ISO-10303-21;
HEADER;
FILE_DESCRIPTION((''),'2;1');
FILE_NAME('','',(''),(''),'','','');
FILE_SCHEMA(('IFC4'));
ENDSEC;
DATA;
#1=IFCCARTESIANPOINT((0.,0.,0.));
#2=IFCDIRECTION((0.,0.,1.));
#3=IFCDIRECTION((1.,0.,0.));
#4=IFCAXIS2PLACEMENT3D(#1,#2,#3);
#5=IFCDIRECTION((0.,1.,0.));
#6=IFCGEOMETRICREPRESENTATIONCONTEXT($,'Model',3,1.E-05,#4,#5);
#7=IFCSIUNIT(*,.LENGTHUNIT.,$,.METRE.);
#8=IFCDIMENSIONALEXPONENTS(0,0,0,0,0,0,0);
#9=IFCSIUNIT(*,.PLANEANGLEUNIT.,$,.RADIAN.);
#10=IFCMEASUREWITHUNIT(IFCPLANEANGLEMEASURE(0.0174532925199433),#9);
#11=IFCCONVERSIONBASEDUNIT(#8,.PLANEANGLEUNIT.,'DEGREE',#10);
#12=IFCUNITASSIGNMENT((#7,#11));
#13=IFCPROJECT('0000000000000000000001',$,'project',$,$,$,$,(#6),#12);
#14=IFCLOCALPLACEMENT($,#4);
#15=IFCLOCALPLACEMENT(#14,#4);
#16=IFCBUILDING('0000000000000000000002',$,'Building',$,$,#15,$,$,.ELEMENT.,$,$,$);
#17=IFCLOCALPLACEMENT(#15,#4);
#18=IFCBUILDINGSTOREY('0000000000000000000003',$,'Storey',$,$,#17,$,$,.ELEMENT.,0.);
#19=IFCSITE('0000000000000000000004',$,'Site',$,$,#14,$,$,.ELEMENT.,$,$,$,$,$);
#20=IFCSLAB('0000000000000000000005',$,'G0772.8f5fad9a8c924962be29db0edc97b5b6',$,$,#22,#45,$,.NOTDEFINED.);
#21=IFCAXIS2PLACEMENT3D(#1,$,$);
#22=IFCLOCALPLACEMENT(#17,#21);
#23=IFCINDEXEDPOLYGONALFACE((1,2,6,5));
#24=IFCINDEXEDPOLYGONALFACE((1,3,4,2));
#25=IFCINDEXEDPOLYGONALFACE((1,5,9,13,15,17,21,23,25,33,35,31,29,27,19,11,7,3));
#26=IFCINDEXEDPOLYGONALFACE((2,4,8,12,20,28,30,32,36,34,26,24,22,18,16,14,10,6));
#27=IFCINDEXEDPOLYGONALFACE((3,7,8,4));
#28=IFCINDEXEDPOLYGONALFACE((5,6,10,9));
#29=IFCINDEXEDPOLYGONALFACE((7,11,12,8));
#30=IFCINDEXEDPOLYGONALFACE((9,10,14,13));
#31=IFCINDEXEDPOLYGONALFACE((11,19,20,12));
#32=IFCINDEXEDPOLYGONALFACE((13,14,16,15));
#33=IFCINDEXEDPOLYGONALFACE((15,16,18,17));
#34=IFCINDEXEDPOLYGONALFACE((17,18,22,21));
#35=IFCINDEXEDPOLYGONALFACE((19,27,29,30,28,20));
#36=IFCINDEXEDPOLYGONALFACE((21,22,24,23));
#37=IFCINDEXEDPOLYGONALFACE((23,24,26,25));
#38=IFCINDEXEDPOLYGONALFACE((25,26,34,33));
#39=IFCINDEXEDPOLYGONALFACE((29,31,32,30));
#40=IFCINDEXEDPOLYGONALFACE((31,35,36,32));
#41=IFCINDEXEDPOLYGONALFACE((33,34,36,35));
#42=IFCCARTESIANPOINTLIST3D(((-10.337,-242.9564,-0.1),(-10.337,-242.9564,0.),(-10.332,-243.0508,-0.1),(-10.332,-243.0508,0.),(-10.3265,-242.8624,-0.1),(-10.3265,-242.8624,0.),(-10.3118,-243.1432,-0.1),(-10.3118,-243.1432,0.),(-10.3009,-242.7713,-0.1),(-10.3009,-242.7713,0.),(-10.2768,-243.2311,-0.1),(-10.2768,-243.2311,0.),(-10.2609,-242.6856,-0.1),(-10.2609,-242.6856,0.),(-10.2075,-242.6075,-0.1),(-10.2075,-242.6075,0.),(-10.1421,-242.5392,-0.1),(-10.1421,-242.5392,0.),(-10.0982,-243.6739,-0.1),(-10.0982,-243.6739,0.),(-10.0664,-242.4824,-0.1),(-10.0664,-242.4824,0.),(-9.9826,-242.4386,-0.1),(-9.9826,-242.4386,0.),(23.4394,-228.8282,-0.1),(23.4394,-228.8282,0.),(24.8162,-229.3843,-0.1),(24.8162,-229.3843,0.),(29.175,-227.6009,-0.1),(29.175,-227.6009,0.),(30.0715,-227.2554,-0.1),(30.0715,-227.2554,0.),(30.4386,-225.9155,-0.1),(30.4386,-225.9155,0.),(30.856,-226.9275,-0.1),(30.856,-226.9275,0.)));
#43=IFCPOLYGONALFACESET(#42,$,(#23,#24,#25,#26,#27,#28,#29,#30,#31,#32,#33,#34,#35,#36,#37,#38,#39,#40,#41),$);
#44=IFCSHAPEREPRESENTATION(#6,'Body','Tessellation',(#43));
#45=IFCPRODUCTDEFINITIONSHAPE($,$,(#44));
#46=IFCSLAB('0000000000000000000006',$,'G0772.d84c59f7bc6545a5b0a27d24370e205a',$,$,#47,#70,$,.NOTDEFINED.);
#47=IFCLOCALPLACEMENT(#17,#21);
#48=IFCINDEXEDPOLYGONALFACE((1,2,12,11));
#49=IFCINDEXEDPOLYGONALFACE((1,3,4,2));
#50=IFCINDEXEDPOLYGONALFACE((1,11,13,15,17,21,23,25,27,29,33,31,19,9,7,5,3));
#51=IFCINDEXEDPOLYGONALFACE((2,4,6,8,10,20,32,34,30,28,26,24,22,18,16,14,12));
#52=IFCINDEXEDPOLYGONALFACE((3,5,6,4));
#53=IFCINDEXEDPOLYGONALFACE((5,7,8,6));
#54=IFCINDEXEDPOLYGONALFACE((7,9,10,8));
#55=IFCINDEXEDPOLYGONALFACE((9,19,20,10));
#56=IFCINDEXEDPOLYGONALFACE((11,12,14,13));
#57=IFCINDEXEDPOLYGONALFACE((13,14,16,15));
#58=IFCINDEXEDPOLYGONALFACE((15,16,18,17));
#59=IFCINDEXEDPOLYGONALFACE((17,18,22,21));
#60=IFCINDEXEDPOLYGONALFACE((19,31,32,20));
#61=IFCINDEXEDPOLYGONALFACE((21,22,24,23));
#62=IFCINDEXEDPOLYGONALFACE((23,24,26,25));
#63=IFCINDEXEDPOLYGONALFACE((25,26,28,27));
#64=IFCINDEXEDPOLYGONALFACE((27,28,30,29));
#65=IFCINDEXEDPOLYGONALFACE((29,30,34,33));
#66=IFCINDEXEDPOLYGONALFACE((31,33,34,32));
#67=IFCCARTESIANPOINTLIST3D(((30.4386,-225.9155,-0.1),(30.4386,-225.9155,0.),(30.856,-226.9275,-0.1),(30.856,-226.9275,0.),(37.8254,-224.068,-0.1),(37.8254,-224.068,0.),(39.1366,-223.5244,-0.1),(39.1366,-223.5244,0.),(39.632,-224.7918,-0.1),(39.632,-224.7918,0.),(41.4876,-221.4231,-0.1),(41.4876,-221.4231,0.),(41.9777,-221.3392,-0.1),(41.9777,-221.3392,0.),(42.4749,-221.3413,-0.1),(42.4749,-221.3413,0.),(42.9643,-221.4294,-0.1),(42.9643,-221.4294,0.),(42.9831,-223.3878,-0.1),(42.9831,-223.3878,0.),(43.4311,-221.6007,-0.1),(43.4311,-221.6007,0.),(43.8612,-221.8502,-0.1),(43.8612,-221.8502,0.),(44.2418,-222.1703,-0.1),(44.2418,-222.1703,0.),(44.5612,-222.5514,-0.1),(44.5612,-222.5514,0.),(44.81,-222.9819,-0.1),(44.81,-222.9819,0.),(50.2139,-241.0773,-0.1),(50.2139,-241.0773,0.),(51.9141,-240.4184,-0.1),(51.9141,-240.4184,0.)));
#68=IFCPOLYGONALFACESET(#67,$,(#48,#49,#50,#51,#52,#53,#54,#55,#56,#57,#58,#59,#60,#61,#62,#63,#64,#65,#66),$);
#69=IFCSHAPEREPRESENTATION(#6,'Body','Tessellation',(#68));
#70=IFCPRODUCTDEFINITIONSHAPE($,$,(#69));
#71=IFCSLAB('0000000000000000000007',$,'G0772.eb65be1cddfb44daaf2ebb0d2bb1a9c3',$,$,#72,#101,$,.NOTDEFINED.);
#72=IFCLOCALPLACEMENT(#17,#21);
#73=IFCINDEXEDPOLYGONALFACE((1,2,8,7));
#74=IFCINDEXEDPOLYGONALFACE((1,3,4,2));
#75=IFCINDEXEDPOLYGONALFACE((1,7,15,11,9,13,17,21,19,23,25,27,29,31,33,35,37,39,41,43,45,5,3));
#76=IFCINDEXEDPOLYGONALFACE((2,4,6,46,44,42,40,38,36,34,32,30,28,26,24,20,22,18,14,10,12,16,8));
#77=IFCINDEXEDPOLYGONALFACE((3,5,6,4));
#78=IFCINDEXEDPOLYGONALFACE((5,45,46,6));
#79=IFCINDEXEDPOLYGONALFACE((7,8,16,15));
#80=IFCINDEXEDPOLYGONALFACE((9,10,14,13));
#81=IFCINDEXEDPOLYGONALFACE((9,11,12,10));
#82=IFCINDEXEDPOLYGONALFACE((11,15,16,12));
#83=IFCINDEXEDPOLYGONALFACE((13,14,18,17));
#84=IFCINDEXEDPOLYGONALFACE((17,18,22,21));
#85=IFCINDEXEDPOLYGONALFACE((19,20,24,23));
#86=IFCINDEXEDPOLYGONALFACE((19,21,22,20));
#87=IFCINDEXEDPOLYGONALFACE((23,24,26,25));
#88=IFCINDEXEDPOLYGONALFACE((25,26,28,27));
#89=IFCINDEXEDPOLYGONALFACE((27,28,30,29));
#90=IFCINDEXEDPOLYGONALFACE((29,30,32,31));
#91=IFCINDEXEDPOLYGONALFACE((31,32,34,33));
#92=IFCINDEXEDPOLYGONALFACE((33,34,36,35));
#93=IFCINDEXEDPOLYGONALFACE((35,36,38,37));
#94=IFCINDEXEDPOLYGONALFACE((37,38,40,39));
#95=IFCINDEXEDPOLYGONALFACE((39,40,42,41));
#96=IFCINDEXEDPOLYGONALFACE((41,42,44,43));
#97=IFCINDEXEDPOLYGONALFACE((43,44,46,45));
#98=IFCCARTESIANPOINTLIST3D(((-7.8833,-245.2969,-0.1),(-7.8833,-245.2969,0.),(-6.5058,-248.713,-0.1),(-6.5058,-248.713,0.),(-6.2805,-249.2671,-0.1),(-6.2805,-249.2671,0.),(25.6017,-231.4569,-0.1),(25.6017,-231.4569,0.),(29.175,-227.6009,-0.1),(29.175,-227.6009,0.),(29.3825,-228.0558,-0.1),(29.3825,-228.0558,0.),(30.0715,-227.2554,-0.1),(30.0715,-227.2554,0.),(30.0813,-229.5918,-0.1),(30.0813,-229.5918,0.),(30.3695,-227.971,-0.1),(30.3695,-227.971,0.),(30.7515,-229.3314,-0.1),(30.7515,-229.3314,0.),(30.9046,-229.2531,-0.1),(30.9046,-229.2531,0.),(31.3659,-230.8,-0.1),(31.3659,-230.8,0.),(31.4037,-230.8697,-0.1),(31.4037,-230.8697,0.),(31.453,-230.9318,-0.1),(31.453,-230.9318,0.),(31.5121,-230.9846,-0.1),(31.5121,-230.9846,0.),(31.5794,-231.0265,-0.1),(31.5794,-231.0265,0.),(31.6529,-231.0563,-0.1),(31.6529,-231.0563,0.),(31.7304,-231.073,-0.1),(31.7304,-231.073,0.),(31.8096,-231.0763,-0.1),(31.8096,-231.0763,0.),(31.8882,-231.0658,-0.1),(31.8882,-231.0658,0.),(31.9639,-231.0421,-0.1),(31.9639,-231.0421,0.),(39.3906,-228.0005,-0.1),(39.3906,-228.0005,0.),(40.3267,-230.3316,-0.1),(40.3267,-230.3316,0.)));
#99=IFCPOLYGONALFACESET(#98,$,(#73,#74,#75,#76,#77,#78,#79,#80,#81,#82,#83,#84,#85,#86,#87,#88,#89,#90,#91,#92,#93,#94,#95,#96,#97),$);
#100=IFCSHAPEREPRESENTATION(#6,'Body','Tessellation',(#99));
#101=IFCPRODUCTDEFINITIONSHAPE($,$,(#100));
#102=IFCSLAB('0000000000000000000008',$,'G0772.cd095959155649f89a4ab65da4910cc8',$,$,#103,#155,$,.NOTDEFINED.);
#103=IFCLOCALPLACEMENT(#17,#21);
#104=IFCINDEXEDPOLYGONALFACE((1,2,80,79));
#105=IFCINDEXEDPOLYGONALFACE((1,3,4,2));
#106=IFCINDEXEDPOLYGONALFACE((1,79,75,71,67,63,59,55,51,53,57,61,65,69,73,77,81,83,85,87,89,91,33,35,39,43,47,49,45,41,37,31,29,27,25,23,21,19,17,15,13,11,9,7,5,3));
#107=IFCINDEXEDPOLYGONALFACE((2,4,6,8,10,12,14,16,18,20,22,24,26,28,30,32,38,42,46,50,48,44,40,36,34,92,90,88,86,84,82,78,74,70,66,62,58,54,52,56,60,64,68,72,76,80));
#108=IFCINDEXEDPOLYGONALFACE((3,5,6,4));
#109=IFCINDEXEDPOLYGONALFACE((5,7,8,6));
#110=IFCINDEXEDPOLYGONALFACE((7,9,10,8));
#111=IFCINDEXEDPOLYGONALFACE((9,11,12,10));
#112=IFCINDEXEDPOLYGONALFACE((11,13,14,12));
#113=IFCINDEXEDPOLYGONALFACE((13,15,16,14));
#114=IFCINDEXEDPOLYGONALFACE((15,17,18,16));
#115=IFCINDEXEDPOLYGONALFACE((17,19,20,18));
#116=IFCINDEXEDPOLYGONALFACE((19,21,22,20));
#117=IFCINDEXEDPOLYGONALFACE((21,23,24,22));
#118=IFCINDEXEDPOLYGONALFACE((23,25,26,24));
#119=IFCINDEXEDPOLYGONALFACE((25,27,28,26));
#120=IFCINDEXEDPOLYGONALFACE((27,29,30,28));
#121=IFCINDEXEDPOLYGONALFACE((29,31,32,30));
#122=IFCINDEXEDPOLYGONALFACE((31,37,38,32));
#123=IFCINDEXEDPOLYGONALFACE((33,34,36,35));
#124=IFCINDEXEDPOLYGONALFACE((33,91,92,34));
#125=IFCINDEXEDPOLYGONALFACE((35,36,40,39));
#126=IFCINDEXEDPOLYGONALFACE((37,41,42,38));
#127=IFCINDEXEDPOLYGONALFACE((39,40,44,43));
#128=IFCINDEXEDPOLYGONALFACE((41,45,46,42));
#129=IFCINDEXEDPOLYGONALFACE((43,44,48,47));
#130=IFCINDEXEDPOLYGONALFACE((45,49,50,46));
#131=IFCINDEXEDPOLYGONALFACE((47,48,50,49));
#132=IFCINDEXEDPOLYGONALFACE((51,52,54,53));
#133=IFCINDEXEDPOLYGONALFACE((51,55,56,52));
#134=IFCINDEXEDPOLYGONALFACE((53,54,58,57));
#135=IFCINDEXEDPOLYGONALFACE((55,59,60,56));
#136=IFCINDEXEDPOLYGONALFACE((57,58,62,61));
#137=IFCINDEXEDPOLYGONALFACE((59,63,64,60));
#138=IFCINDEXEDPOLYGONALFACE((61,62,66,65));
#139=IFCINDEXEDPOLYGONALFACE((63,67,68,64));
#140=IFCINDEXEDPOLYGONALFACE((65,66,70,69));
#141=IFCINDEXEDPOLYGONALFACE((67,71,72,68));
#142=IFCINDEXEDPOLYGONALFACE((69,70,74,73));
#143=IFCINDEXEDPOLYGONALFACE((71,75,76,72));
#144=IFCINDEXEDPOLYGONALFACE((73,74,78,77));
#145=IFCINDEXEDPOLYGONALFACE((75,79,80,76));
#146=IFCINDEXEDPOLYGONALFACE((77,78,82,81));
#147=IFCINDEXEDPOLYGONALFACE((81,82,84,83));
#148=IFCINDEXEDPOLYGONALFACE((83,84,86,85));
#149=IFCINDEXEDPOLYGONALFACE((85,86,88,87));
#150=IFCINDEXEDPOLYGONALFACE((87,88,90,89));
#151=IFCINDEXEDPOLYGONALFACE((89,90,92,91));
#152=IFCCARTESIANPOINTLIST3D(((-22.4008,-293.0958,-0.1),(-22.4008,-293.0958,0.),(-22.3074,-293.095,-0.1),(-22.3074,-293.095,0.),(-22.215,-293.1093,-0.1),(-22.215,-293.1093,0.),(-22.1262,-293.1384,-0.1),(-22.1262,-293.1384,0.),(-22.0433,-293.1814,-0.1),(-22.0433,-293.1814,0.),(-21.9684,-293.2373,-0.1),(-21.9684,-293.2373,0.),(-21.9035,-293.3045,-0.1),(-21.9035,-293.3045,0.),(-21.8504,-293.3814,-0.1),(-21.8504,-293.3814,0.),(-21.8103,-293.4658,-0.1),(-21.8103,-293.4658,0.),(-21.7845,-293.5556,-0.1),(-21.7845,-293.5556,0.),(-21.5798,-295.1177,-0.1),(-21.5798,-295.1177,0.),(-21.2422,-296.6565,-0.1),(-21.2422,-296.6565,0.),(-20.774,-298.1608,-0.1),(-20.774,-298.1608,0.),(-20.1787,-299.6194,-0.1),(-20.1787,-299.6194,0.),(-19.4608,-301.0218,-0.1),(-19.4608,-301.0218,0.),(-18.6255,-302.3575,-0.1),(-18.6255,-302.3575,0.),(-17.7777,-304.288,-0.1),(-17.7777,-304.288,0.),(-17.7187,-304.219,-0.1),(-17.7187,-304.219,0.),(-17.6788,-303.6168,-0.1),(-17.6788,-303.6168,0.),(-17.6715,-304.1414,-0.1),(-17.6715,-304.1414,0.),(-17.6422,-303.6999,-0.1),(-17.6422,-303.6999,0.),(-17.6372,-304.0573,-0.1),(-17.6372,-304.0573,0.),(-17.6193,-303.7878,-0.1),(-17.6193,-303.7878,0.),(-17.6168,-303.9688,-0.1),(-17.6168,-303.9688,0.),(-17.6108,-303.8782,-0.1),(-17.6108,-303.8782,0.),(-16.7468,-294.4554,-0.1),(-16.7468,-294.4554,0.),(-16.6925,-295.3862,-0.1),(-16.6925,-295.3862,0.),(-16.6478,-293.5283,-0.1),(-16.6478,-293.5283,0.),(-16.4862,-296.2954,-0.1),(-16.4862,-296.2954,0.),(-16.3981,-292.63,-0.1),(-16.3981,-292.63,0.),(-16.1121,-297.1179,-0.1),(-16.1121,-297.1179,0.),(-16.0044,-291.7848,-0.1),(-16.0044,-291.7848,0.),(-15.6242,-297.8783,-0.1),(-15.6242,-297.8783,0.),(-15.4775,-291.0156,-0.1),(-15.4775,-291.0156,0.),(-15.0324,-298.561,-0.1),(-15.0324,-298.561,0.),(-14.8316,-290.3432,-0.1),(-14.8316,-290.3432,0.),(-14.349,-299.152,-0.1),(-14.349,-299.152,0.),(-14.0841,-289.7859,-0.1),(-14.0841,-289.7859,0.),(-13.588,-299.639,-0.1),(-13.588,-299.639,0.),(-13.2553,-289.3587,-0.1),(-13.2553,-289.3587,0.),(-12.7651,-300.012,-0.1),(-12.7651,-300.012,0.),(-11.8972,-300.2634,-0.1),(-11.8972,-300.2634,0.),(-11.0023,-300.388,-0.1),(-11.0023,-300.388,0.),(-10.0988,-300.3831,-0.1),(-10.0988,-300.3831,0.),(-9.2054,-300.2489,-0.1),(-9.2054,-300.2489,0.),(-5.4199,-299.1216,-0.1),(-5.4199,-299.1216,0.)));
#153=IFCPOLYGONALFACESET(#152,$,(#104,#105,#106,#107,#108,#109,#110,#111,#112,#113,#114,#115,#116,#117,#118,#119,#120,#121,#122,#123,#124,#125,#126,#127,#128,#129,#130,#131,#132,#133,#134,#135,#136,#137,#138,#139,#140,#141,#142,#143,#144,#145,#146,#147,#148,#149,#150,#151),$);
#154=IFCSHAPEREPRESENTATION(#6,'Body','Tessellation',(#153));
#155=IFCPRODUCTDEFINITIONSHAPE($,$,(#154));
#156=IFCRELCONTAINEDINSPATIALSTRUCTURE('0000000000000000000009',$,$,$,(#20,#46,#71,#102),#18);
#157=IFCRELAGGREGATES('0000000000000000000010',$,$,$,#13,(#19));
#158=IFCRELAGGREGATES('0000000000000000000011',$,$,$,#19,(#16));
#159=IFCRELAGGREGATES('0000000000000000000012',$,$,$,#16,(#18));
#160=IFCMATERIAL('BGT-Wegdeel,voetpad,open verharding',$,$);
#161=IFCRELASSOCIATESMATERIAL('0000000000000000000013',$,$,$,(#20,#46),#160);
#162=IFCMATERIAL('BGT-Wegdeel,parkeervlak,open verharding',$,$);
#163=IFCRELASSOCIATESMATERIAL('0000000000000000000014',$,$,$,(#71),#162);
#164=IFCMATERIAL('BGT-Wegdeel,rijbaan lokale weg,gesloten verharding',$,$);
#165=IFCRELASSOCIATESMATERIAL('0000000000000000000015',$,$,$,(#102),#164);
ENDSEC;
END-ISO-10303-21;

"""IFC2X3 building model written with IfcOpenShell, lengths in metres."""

from ifc_helpers import new_model, entity, si_unit, converted_unit, direction, frame, origin_with_axes, place, context, project, spatial, polyline, outline, extrude, material, element, save


model = new_model("IFC2X3")

# Units and contexts
model_context = context("Model", 3, precision=1e-05, world=origin_with_axes(), true_north=direction((0.0, 1.0, 0.0)))
ifc_project = project(units=[si_unit("LENGTHUNIT", "METRE"), converted_unit("PLANEANGLEUNIT", "DEGREE", entity("IfcPlaneAngleMeasure", 0.0174532925199433), si_unit("PLANEANGLEUNIT", "RADIAN"), dimensions=[0, 0, 0, 0, 0, 0, 0])], contexts=[model_context])

# Site, building, storey
site_placement = place(None, origin_with_axes())
site = spatial("IfcSite", under=ifc_project, at=site_placement, Name="Site", CompositionType="ELEMENT")
building_placement = place(site_placement, origin_with_axes())
building = spatial("IfcBuilding", under=site, at=building_placement, Name="Building", CompositionType="ELEMENT")
storey_placement = place(building_placement, origin_with_axes())
storey = spatial("IfcBuildingStorey", under=building, at=storey_placement, Name="Storey", CompositionType="ELEMENT", Elevation=0.0)

# Slabs
ifc_material_1 = material(Name="BGT-Wegdeel,voetpad,open verharding")
ifc_material_2 = material(Name="BGT-Wegdeel,parkeervlak,open verharding")
ifc_material_3 = material(Name="BGT-Wegdeel,rijbaan lokale weg,gesloten verharding")
slab_1_placement = place(storey_placement, frame((0.0, 0.0, -0.1), z_axis=(0.0, 0.0, 1.0), x_axis=(1.0, 0.0, 0.0)))
element("IfcSlab", 1, at=slab_1_placement, inside=storey, material=ifc_material_1, Name="G0772.8f5fad9a8c924962be29db0edc97b5b6", PredefinedType="NOTDEFINED", context=model_context, shape_type="SweptSolid", body=[
    extrude(outline(polyline([(23.4394, -228.8282), (30.4386, -225.9155), (30.856, -226.9275), (30.0715, -227.2554), (29.175, -227.6009), (24.8162, -229.3843), (-10.0982, -243.6739), (-10.2768, -243.2311), (-10.3118, -243.1432), (-10.332, -243.0508), (-10.337, -242.9564), (-10.3265, -242.8624), (-10.3009, -242.7713), (-10.2609, -242.6856), (-10.2075, -242.6075), (-10.1421, -242.5392), (-10.0664, -242.4824), (-9.9826, -242.4386), (23.4394, -228.8282)])), origin_with_axes(), (0.0, 0.0, 1.0), 0.1),
])
slab_2_placement = place(storey_placement, frame((0.0, 0.0, -0.1), z_axis=(0.0, 0.0, 1.0), x_axis=(1.0, 0.0, 0.0)))
element("IfcSlab", 2, at=slab_2_placement, inside=storey, material=ifc_material_1, Name="G0772.d84c59f7bc6545a5b0a27d24370e205a", PredefinedType="NOTDEFINED", context=model_context, shape_type="SweptSolid", body=[
    extrude(outline(polyline([(51.9141, -240.4184), (50.2139, -241.0773), (42.9831, -223.3878), (39.632, -224.7918), (39.1366, -223.5244), (37.8254, -224.068), (30.856, -226.9275), (30.4386, -225.9155), (41.4876, -221.4231), (41.9777, -221.3392), (42.4749, -221.3413), (42.9643, -221.4294), (43.4311, -221.6007), (43.8612, -221.8502), (44.2418, -222.1703), (44.5612, -222.5514), (44.81, -222.9819), (51.9141, -240.4184)])), origin_with_axes(), (0.0, 0.0, 1.0), 0.1),
])
slab_3_placement = place(storey_placement, frame((0.0, 0.0, -0.1), z_axis=(0.0, 0.0, 1.0), x_axis=(1.0, 0.0, 0.0)))
element("IfcSlab", 3, at=slab_3_placement, inside=storey, material=ifc_material_2, Name="G0772.eb65be1cddfb44daaf2ebb0d2bb1a9c3", PredefinedType="NOTDEFINED", context=model_context, shape_type="SweptSolid", body=[
    extrude(outline(polyline([(25.6017, -231.4569), (30.0813, -229.5918), (29.3825, -228.0558), (29.175, -227.6009), (30.0715, -227.2554), (30.3695, -227.971), (30.9046, -229.2531), (30.7515, -229.3314), (31.3659, -230.8), (31.4037, -230.8697), (31.453, -230.9318), (31.5121, -230.9846), (31.5794, -231.0265), (31.6529, -231.0563), (31.7304, -231.073), (31.8096, -231.0763), (31.8882, -231.0658), (31.9639, -231.0421), (39.3906, -228.0005), (40.3267, -230.3316), (-6.2805, -249.2671), (-6.5058, -248.713), (-7.8833, -245.2969), (25.6017, -231.4569)])), origin_with_axes(), (0.0, 0.0, 1.0), 0.1),
])
slab_4_placement = place(storey_placement, frame((0.0, 0.0, -0.1), z_axis=(0.0, 0.0, 1.0), x_axis=(1.0, 0.0, 0.0)))
element("IfcSlab", 4, at=slab_4_placement, inside=storey, material=ifc_material_3, Name="G0772.cd095959155649f89a4ab65da4910cc8", PredefinedType="NOTDEFINED", context=model_context, shape_type="SweptSolid", body=[
    extrude(outline(polyline([(-14.0841, -289.7859), (-14.8316, -290.3432), (-15.4775, -291.0156), (-16.0044, -291.7848), (-16.3981, -292.63), (-16.6478, -293.5283), (-16.7468, -294.4554), (-16.6925, -295.3862), (-16.4862, -296.2954), (-16.1121, -297.1179), (-15.6242, -297.8783), (-15.0324, -298.561), (-14.349, -299.152), (-13.588, -299.639), (-12.7651, -300.012), (-11.8972, -300.2634), (-11.0023, -300.388), (-10.0988, -300.3831), (-9.2054, -300.2489), (-5.4199, -299.1216), (-17.7777, -304.288), (-17.7187, -304.219), (-17.6715, -304.1414), (-17.6372, -304.0573), (-17.6168, -303.9688), (-17.6108, -303.8782), (-17.6193, -303.7878), (-17.6422, -303.6999), (-17.6788, -303.6168), (-18.6255, -302.3575), (-19.4608, -301.0218), (-20.1787, -299.6194), (-20.774, -298.1608), (-21.2422, -296.6565), (-21.5798, -295.1177), (-21.7845, -293.5556), (-21.8103, -293.4658), (-21.8504, -293.3814), (-21.9035, -293.3045), (-21.9684, -293.2373), (-22.0433, -293.1814), (-22.1262, -293.1384), (-22.215, -293.1093), (-22.3074, -293.095), (-22.4008, -293.0958), (-13.2553, -289.3587), (-14.0841, -289.7859)])), origin_with_axes(), (0.0, 0.0, 1.0), 0.1),
])

save(model, "model.ifc")
